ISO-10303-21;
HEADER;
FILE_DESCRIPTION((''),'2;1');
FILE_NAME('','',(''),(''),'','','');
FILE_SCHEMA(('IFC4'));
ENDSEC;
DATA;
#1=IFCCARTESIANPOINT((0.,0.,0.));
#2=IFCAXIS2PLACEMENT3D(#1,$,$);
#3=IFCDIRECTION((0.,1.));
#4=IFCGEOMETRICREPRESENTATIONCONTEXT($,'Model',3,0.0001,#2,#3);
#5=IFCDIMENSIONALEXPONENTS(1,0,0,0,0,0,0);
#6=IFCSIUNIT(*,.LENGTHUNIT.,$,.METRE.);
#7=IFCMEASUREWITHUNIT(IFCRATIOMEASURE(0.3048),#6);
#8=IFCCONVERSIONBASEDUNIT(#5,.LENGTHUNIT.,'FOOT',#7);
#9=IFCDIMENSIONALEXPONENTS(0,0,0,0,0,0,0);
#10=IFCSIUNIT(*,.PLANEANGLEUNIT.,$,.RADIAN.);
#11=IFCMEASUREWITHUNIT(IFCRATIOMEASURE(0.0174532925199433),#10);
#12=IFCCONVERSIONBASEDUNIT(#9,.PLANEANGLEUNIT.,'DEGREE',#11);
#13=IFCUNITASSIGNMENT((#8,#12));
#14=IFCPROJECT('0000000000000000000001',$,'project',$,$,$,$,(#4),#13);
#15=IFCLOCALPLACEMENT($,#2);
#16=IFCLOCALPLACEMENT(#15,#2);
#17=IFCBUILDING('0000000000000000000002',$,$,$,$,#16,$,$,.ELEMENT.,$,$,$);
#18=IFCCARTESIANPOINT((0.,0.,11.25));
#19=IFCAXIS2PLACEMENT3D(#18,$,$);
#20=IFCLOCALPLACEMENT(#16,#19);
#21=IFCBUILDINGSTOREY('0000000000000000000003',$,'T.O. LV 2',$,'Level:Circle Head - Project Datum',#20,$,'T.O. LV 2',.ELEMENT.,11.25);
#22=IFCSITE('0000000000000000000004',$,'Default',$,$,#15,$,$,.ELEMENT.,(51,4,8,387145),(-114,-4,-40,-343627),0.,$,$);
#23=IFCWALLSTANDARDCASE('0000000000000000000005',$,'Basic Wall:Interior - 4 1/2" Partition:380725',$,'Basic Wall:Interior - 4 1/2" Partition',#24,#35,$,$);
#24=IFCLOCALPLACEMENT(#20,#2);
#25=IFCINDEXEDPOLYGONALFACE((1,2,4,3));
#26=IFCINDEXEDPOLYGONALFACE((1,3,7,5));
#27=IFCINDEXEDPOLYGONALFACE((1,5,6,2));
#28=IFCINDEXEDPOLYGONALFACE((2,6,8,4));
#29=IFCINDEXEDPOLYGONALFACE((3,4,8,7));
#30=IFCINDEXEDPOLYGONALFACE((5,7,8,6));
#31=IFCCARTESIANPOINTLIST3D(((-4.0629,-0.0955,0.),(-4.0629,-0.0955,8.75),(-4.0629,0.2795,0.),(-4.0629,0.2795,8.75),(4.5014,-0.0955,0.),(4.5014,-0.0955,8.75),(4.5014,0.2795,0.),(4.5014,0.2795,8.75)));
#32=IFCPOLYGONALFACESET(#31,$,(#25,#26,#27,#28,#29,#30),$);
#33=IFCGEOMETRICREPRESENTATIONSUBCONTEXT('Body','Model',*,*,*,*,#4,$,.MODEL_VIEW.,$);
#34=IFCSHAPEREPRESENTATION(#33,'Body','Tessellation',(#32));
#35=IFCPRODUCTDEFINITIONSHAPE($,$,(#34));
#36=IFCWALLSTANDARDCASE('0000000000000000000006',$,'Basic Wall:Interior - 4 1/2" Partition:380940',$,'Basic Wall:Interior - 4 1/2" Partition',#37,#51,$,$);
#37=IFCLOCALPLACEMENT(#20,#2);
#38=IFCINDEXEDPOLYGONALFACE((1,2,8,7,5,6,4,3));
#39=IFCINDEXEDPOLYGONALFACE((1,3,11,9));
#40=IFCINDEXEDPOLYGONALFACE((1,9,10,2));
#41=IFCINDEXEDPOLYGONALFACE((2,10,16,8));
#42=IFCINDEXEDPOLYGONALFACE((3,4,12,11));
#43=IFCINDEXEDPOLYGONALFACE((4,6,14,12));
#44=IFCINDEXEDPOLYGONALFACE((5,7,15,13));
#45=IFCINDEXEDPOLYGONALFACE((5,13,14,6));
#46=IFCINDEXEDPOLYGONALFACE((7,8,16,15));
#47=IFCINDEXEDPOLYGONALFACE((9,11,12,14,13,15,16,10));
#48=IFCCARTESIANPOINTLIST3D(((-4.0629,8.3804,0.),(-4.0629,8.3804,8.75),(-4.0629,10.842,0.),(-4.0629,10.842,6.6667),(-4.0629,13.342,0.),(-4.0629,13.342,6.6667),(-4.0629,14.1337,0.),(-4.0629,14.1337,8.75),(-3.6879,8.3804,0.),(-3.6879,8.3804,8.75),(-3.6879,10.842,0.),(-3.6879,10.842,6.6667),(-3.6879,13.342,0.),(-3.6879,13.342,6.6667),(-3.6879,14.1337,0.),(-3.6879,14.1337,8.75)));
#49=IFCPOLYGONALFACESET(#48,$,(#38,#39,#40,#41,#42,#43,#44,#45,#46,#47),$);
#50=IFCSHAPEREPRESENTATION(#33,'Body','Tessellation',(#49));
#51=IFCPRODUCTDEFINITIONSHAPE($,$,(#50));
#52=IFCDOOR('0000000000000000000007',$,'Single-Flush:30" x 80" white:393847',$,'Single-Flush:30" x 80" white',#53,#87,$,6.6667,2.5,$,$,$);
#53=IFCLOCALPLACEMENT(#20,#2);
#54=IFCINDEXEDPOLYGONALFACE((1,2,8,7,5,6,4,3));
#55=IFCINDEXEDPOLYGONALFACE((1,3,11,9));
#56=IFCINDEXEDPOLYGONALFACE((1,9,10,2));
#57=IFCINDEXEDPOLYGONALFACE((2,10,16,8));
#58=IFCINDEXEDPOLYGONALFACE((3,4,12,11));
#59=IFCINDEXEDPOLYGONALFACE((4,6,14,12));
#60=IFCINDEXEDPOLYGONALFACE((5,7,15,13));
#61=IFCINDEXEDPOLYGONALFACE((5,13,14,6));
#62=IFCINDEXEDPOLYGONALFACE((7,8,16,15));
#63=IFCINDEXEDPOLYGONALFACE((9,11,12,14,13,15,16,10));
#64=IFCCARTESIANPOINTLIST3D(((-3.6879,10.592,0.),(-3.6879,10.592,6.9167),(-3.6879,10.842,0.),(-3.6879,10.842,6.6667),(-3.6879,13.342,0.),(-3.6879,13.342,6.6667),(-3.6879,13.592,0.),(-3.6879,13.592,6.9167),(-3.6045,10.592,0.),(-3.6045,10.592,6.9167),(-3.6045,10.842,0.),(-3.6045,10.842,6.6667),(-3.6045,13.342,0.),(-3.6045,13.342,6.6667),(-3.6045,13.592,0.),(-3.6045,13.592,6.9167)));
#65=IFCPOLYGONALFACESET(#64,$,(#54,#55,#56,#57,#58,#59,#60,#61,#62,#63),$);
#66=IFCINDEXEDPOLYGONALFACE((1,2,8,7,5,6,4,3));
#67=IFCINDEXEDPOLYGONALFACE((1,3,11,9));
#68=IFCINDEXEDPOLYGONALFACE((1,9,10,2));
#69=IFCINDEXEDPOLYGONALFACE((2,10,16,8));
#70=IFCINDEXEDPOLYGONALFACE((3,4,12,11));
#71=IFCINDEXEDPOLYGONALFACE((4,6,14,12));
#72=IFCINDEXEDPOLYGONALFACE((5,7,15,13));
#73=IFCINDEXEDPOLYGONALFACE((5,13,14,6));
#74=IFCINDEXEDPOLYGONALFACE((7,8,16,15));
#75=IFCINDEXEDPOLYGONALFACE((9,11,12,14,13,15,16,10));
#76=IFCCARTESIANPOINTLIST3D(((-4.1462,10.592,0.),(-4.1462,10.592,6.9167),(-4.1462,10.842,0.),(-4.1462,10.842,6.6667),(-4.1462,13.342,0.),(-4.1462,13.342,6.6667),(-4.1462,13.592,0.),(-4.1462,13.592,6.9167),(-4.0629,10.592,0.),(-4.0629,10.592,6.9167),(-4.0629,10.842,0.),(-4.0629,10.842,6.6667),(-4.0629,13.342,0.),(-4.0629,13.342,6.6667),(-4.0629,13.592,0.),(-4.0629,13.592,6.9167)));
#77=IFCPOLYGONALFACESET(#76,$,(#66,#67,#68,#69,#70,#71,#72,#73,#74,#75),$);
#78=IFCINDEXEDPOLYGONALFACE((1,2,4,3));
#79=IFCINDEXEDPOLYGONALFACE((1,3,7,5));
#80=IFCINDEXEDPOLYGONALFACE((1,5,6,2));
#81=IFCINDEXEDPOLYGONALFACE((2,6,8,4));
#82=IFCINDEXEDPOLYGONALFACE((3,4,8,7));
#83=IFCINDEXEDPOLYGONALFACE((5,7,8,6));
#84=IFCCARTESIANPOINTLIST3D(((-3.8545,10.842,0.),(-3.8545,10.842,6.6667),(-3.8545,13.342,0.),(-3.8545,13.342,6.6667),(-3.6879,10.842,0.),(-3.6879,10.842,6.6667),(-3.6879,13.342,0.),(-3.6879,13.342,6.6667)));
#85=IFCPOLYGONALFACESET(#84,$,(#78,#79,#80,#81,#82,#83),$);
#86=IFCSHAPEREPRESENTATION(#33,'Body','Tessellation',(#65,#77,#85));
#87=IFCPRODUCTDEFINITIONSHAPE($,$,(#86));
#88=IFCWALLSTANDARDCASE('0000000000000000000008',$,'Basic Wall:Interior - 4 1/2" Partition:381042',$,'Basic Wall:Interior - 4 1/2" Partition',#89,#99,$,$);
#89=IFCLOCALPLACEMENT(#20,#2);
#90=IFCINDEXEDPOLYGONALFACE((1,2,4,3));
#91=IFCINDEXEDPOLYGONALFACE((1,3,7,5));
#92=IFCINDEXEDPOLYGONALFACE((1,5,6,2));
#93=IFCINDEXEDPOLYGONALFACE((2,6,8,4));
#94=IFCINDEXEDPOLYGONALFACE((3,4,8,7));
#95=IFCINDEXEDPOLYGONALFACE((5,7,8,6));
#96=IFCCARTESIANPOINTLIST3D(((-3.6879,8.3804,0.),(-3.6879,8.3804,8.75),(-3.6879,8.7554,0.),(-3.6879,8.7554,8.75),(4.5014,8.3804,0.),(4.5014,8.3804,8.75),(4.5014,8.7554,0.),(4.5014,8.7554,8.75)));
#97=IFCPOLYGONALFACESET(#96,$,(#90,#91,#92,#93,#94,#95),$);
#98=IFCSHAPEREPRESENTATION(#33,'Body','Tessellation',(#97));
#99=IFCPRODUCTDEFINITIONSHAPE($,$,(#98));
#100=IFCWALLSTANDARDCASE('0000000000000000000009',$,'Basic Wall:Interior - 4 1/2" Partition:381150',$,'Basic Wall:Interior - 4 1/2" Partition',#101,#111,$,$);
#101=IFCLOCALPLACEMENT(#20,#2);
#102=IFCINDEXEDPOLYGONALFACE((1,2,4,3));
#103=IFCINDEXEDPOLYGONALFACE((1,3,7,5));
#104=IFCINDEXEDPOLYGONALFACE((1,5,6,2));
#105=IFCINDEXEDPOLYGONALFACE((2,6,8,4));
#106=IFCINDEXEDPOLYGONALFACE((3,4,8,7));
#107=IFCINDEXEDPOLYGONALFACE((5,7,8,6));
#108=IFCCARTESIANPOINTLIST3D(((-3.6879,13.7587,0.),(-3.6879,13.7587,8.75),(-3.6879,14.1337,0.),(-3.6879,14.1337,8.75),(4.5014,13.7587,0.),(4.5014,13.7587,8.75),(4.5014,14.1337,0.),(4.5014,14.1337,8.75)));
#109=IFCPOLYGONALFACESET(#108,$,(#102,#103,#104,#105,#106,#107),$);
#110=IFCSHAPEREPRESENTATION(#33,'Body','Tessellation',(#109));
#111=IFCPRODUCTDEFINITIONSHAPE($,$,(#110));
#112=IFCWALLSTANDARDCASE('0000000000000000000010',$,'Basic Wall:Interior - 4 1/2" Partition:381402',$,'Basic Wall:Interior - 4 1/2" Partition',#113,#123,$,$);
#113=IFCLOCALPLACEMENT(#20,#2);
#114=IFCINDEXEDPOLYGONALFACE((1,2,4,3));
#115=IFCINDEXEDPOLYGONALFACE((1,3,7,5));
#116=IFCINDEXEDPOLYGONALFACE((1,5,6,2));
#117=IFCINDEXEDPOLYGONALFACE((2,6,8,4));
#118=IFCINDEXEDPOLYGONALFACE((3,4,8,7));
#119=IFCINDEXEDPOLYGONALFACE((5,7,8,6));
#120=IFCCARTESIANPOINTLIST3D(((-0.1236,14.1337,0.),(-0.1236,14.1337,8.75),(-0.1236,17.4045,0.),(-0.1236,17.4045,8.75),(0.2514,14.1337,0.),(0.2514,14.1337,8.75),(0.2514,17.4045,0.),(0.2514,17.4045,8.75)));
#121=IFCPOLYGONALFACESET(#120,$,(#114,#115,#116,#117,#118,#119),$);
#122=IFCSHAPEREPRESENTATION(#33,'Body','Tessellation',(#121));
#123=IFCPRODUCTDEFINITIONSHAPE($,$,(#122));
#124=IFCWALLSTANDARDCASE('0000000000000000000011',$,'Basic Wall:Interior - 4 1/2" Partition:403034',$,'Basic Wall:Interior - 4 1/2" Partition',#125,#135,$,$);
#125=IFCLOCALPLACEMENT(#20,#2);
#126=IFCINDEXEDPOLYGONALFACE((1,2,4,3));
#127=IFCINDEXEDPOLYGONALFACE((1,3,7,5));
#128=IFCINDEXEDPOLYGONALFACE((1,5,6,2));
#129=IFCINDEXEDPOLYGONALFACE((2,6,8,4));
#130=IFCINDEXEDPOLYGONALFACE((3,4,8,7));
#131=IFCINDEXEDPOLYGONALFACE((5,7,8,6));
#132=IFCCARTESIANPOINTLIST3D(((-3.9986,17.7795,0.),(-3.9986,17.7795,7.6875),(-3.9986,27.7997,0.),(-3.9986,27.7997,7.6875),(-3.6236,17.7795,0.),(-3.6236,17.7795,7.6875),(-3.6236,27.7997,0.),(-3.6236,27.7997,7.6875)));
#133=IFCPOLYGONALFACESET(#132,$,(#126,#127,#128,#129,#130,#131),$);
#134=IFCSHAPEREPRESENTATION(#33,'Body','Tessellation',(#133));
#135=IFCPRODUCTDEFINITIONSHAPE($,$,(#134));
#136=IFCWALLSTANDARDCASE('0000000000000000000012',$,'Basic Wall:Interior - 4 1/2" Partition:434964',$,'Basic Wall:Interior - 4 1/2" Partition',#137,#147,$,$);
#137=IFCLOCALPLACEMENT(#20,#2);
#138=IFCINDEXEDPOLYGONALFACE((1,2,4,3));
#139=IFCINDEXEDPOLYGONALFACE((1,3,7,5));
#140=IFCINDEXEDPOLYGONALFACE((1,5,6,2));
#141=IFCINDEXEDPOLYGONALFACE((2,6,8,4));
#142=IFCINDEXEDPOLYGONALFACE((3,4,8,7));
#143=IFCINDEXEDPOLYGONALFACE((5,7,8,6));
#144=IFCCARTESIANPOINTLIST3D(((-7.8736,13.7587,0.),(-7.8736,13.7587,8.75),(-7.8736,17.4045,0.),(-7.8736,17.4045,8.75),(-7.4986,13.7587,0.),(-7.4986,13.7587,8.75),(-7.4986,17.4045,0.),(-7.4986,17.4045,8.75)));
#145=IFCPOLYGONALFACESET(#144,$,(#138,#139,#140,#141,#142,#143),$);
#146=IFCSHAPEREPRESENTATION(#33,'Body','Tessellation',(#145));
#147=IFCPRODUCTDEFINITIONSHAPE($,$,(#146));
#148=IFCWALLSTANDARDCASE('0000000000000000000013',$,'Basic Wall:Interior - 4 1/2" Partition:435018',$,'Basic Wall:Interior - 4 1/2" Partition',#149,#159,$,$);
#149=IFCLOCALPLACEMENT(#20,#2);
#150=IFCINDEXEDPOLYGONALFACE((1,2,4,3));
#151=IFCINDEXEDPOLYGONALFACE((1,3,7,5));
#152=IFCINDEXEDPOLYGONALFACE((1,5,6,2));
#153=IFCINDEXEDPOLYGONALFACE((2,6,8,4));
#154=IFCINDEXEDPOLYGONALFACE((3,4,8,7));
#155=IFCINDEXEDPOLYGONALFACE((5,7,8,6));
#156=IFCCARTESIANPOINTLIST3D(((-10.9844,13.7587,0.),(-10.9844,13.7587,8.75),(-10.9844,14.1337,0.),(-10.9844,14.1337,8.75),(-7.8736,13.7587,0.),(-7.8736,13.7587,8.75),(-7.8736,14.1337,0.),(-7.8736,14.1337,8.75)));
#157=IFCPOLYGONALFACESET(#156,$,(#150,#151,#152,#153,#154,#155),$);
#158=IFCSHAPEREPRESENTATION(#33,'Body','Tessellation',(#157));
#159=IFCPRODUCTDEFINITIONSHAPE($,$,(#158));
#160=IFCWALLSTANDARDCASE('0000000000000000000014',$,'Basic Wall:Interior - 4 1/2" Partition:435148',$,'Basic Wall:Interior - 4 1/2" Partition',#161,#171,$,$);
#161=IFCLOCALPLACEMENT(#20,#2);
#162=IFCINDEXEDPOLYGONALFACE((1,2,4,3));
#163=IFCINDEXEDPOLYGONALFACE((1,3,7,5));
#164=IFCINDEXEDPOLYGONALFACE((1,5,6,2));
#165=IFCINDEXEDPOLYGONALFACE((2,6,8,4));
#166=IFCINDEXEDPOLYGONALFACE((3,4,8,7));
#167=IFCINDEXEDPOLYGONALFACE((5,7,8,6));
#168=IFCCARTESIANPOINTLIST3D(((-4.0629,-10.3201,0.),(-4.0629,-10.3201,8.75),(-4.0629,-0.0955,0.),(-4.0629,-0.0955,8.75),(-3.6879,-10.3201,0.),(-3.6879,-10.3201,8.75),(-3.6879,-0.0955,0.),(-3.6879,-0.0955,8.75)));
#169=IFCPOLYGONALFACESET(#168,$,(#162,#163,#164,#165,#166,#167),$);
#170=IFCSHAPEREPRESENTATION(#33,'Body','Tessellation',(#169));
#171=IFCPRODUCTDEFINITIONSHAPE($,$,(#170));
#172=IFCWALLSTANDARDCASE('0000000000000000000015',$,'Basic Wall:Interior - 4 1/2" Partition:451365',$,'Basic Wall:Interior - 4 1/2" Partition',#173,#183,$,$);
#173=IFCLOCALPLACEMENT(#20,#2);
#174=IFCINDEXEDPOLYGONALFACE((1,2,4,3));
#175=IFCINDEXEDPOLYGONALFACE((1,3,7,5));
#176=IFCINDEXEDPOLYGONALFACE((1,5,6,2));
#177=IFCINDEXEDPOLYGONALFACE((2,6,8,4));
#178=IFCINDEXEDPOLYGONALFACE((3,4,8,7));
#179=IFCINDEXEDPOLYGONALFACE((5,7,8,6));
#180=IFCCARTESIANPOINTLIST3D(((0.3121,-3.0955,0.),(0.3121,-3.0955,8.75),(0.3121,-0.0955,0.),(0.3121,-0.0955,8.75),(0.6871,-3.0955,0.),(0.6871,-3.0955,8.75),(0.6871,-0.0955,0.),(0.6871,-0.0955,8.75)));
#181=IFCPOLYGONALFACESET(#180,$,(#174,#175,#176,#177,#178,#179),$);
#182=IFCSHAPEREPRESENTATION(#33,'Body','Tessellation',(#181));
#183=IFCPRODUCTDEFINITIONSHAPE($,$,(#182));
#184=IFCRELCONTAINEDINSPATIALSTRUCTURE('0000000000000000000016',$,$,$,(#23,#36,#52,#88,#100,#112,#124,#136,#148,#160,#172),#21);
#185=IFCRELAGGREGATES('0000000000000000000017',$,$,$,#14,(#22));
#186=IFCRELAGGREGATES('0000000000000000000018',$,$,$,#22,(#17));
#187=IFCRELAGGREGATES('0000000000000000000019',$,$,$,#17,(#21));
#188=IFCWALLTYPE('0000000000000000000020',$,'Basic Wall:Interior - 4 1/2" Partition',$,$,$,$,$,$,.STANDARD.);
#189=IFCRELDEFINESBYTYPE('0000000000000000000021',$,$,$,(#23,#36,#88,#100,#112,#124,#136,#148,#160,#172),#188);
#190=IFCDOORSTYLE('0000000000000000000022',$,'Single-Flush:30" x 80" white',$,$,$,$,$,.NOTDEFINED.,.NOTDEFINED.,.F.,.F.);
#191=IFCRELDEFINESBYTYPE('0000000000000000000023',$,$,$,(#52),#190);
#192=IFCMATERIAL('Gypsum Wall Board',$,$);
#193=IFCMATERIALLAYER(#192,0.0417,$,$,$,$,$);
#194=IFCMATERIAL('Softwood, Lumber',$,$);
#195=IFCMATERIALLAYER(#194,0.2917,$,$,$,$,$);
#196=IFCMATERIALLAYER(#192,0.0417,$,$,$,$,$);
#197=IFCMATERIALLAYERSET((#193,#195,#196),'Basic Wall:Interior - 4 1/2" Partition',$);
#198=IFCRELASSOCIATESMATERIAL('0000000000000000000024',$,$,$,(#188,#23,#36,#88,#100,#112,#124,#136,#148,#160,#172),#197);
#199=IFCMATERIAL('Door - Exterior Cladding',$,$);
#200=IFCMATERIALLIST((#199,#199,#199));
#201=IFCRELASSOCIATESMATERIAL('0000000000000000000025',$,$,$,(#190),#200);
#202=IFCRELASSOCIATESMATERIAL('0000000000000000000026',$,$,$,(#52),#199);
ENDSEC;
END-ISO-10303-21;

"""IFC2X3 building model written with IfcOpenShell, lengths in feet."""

from ifc_helpers import new_model, entity, si_unit, converted_unit, direction, frame, frame_2d, origin, origin_2d_with_axis, place, context, subcontext, project, spatial, polyline, rectangle, outline, extrude, source, transform, mapped, material, material_list, layer, layer_set, layer_usage, type_object, type_shapes, element, fill, save


model = new_model("IFC2X3")

# Units and contexts
model_context = context("Model", 3, precision=0.0001, world=origin(), true_north=direction((0.0, 1.0)))
body_context = subcontext(model_context, "Body", "Model", "MODEL_VIEW")
ifc_project = project(units=[converted_unit("LENGTHUNIT", "FOOT", entity("IfcRatioMeasure", 0.3048), si_unit("LENGTHUNIT", "METRE"), dimensions=[1, 0, 0, 0, 0, 0, 0]), converted_unit("PLANEANGLEUNIT", "DEGREE", entity("IfcRatioMeasure", 0.0174532925199433), si_unit("PLANEANGLEUNIT", "RADIAN"), dimensions=[0, 0, 0, 0, 0, 0, 0])], contexts=[model_context])

# Site, building, storey
site_placement = place(None, origin())
site = spatial("IfcSite", under=ifc_project, at=site_placement, Name="Default", CompositionType="ELEMENT", RefLatitude=(51, 4, 8, 387145), RefLongitude=(-114, -4, -40, -343627), RefElevation=0.0)
building_placement = place(site_placement, origin())
building = spatial("IfcBuilding", under=site, at=building_placement, CompositionType="ELEMENT")
storey_placement = place(building_placement, frame((0.0, 0.0, 11.25)))
storey = spatial("IfcBuildingStorey", under=building, at=storey_placement, Name="T.O. LV 2", ObjectType="Level:Circle Head - Project Datum", LongName="T.O. LV 2", CompositionType="ELEMENT", Elevation=11.25)

# Shared definitions
ifc_material_1 = material(Name="Gypsum Wall Board")
ifc_layer_1 = layer(ifc_material_1, 0.0417)
ifc_material_2 = material(Name="Softwood, Lumber")
ifc_layer_2 = layer(ifc_material_2, 0.2917)
ifc_layer_3 = layer(ifc_material_1, 0.0417)
ifc_layer_set_1 = layer_set([ifc_layer_1, ifc_layer_2, ifc_layer_3], Name="Basic Wall:Interior - 4 1/2\" Partition")
wall_type_1 = type_object("IfcWallType", Name="Basic Wall:Interior - 4 1/2\" Partition", PredefinedType="STANDARD", material=ifc_layer_set_1)
ifc_material_3 = material(Name="Door - Exterior Cladding")

# Wall
ifc_layer_usage_1 = layer_usage(ifc_layer_set_1, "AXIS2", "NEGATIVE", 0.1875)
wall_1_placement = place(storey_placement, frame((-4.0629, 0.092, 0.0)))
element("IfcWallStandardCase", 1, at=wall_1_placement, inside=storey, type_object=wall_type_1, material=ifc_layer_usage_1, Name="Basic Wall:Interior - 4 1/2\" Partition:380725", ObjectType="Basic Wall:Interior - 4 1/2\" Partition", context=body_context, shape_type="SweptSolid", body=[
    extrude(rectangle(XDim=8.5643, YDim=0.375, at=frame_2d((4.2822, 0.0), x_axis=(-1.0, 0.0))), origin(), (0.0, 0.0, 1.0), 8.75),
])

# Wall, opening, door
ifc_layer_usage_2 = layer_usage(ifc_layer_set_1, "AXIS2", "NEGATIVE", 0.1875)
wall_2_placement = place(storey_placement, frame((-3.8754, 14.1337, 0.0), z_axis=(0.0, 0.0, 1.0), x_axis=(0.0, -1.0, 0.0)))
wall_2 = element("IfcWallStandardCase", 2, at=wall_2_placement, inside=storey, type_object=wall_type_1, material=ifc_layer_usage_2, Name="Basic Wall:Interior - 4 1/2\" Partition:380940", ObjectType="Basic Wall:Interior - 4 1/2\" Partition", context=body_context, shape_type="SweptSolid", body=[
    extrude(rectangle(XDim=5.7533, YDim=0.375, at=frame_2d((2.8766, 0.0), x_axis=(-1.0, 0.0))), origin(), (0.0, 0.0, 1.0), 8.75),
])
opening_1_placement = place(wall_2_placement, frame((0.7917, -0.1875, 0.0)))
opening_1 = element("IfcOpeningElement", 3, at=opening_1_placement, cuts=wall_2, ObjectType="Opening", context=body_context, shape_type="SweptSolid", body=[
    extrude(rectangle(XDim=2.5, YDim=6.6667, at=frame_2d((3.3333, 1.25), x_axis=(0.0, -1.0))), frame((0.0, 0.0, 0.0), z_axis=(0.0, 1.0, 0.0), x_axis=(0.0, 0.0, 1.0)), (0.0, 0.0, 1.0), 0.375),
])
ifc_material_list_1 = material_list([ifc_material_3, ifc_material_3, ifc_material_3])
door_style_1 = type_object("IfcDoorStyle", Name="Single-Flush:30\" x 80\" white", ConstructionType="NOTDEFINED", OperationType="NOTDEFINED", ParameterTakesPrecedence=False, Sizeable=False, material=ifc_material_list_1)
shared_shape_1 = source(origin(), body_context, "Body", "SweptSolid", [
    extrude(outline(polyline([(-1.5, -3.5208), (1.5, -3.5208), (1.5, 3.3958), (1.25, 3.3958), (1.25, -3.2708), (-1.25, -3.2708), (-1.25, 3.3958), (-1.5, 3.3958), (-1.5, -3.5208)])), frame((1.25, 0.4583, 3.3958), z_axis=(0.0, -1.0, 0.0), x_axis=(-1.0, 0.0, 0.0)), (0.0, 0.0, 1.0), 0.0833),
    extrude(outline(polyline([(-3.5208, -1.5), (3.3958, -1.5), (3.3958, -1.25), (-3.2708, -1.25), (-3.2708, 1.25), (3.3958, 1.25), (3.3958, 1.5), (-3.5208, 1.5), (-3.5208, -1.5)])), frame((1.25, 0.0, 3.3958), z_axis=(0.0, -1.0, 0.0), x_axis=(0.0, 0.0, -1.0)), (0.0, 0.0, 1.0), 0.0833),
    extrude(rectangle(XDim=2.5, YDim=0.1667, at=origin_2d_with_axis()), frame((1.25, 0.2917, 0.0)), (0.0, 0.0, 1.0), 6.6667),
])
type_shapes(door_style_1, [shared_shape_1])
door_1_placement = place(opening_1_placement, origin())
door_1 = element("IfcDoor", 4, at=door_1_placement, inside=storey, type_object=door_style_1, material=ifc_material_3, Name="Single-Flush:30\" x 80\" white:393847", ObjectType="Single-Flush:30\" x 80\" white", OverallHeight=6.6667, OverallWidth=2.5, context=body_context, shape_type="MappedRepresentation", body=[
    mapped(shared_shape_1, transform((0.0, 0.0, 0.0), scale=1.0)),
])
fill(opening_1, door_1)

# Walls
ifc_layer_usage_3 = layer_usage(ifc_layer_set_1, "AXIS2", "NEGATIVE", 0.1875)
wall_3_placement = place(storey_placement, frame((-3.6879, 8.5679, 0.0)))
element("IfcWallStandardCase", 5, at=wall_3_placement, inside=storey, type_object=wall_type_1, material=ifc_layer_usage_3, Name="Basic Wall:Interior - 4 1/2\" Partition:381042", ObjectType="Basic Wall:Interior - 4 1/2\" Partition", context=body_context, shape_type="SweptSolid", body=[
    extrude(rectangle(XDim=8.1893, YDim=0.375, at=frame_2d((4.0947, 0.0), x_axis=(-1.0, 0.0))), origin(), (0.0, 0.0, 1.0), 8.75),
])
ifc_layer_usage_4 = layer_usage(ifc_layer_set_1, "AXIS2", "NEGATIVE", 0.1875)
wall_4_placement = place(storey_placement, frame((-3.6879, 13.9462, 0.0)))
element("IfcWallStandardCase", 6, at=wall_4_placement, inside=storey, type_object=wall_type_1, material=ifc_layer_usage_4, Name="Basic Wall:Interior - 4 1/2\" Partition:381150", ObjectType="Basic Wall:Interior - 4 1/2\" Partition", context=body_context, shape_type="SweptSolid", body=[
    extrude(rectangle(XDim=8.1893, YDim=0.375, at=frame_2d((4.0947, 0.0), x_axis=(-1.0, 0.0))), origin(), (0.0, 0.0, 1.0), 8.75),
])
ifc_layer_usage_5 = layer_usage(ifc_layer_set_1, "AXIS2", "NEGATIVE", 0.1875)
wall_5_placement = place(storey_placement, frame((0.0639, 17.4045, 0.0), z_axis=(0.0, 0.0, 1.0), x_axis=(0.0, -1.0, 0.0)))
element("IfcWallStandardCase", 7, at=wall_5_placement, inside=storey, type_object=wall_type_1, material=ifc_layer_usage_5, Name="Basic Wall:Interior - 4 1/2\" Partition:381402", ObjectType="Basic Wall:Interior - 4 1/2\" Partition", context=body_context, shape_type="SweptSolid", body=[
    extrude(rectangle(XDim=3.2708, YDim=0.375, at=frame_2d((1.6354, 0.0), x_axis=(-1.0, 0.0))), origin(), (0.0, 0.0, 1.0), 8.75),
])
ifc_layer_usage_6 = layer_usage(ifc_layer_set_1, "AXIS2", "NEGATIVE", 0.1875)
wall_6_placement = place(storey_placement, frame((-3.8111, 27.7997, 0.0), z_axis=(0.0, 0.0, 1.0), x_axis=(0.0, -1.0, 0.0)))
element("IfcWallStandardCase", 8, at=wall_6_placement, inside=storey, type_object=wall_type_1, material=ifc_layer_usage_6, Name="Basic Wall:Interior - 4 1/2\" Partition:403034", ObjectType="Basic Wall:Interior - 4 1/2\" Partition", context=body_context, shape_type="SweptSolid", body=[
    extrude(rectangle(XDim=10.0202, YDim=0.375, at=frame_2d((5.0101, 0.0), x_axis=(-1.0, 0.0))), origin(), (0.0, 0.0, 1.0), 7.6875),
])
ifc_layer_usage_7 = layer_usage(ifc_layer_set_1, "AXIS2", "NEGATIVE", 0.1875)
wall_7_placement = place(storey_placement, frame((-7.6861, 17.4045, 0.0), z_axis=(0.0, 0.0, 1.0), x_axis=(0.0, -1.0, 0.0)))
element("IfcWallStandardCase", 9, at=wall_7_placement, inside=storey, type_object=wall_type_1, material=ifc_layer_usage_7, Name="Basic Wall:Interior - 4 1/2\" Partition:434964", ObjectType="Basic Wall:Interior - 4 1/2\" Partition", context=body_context, shape_type="SweptSolid", body=[
    extrude(rectangle(XDim=3.6458, YDim=0.375, at=frame_2d((1.8229, 0.0), x_axis=(-1.0, 0.0))), origin(), (0.0, 0.0, 1.0), 8.75),
])
ifc_layer_usage_8 = layer_usage(ifc_layer_set_1, "AXIS2", "NEGATIVE", 0.1875)
wall_8_placement = place(storey_placement, frame((-7.8736, 13.9462, 0.0), z_axis=(0.0, 0.0, 1.0), x_axis=(-1.0, 0.0, 0.0)))
element("IfcWallStandardCase", 10, at=wall_8_placement, inside=storey, type_object=wall_type_1, material=ifc_layer_usage_8, Name="Basic Wall:Interior - 4 1/2\" Partition:435018", ObjectType="Basic Wall:Interior - 4 1/2\" Partition", context=body_context, shape_type="SweptSolid", body=[
    extrude(rectangle(XDim=3.1108, YDim=0.375, at=frame_2d((1.5554, 0.0), x_axis=(-1.0, 0.0))), origin(), (0.0, 0.0, 1.0), 8.75),
])
ifc_layer_usage_9 = layer_usage(ifc_layer_set_1, "AXIS2", "NEGATIVE", 0.1875)
wall_9_placement = place(storey_placement, frame((-3.8754, -0.0955, 0.0), z_axis=(0.0, 0.0, 1.0), x_axis=(0.0, -1.0, 0.0)))
element("IfcWallStandardCase", 11, at=wall_9_placement, inside=storey, type_object=wall_type_1, material=ifc_layer_usage_9, Name="Basic Wall:Interior - 4 1/2\" Partition:435148", ObjectType="Basic Wall:Interior - 4 1/2\" Partition", context=body_context, shape_type="SweptSolid", body=[
    extrude(rectangle(XDim=10.2246, YDim=0.375, at=frame_2d((5.1123, 0.0), x_axis=(-1.0, 0.0))), origin(), (0.0, 0.0, 1.0), 8.75),
])
ifc_layer_usage_10 = layer_usage(ifc_layer_set_1, "AXIS2", "NEGATIVE", 0.1875)
wall_10_placement = place(storey_placement, frame((0.4996, -0.0955, 0.0), z_axis=(0.0, 0.0, 1.0), x_axis=(0.0, -1.0, 0.0)))
element("IfcWallStandardCase", 12, at=wall_10_placement, inside=storey, type_object=wall_type_1, material=ifc_layer_usage_10, Name="Basic Wall:Interior - 4 1/2\" Partition:451365", ObjectType="Basic Wall:Interior - 4 1/2\" Partition", context=body_context, shape_type="SweptSolid", body=[
    extrude(rectangle(XDim=3.0, YDim=0.375, at=frame_2d((1.5, 0.0), x_axis=(-1.0, 0.0))), origin(), (0.0, 0.0, 1.0), 8.75),
])

save(model, "model.ifc")
